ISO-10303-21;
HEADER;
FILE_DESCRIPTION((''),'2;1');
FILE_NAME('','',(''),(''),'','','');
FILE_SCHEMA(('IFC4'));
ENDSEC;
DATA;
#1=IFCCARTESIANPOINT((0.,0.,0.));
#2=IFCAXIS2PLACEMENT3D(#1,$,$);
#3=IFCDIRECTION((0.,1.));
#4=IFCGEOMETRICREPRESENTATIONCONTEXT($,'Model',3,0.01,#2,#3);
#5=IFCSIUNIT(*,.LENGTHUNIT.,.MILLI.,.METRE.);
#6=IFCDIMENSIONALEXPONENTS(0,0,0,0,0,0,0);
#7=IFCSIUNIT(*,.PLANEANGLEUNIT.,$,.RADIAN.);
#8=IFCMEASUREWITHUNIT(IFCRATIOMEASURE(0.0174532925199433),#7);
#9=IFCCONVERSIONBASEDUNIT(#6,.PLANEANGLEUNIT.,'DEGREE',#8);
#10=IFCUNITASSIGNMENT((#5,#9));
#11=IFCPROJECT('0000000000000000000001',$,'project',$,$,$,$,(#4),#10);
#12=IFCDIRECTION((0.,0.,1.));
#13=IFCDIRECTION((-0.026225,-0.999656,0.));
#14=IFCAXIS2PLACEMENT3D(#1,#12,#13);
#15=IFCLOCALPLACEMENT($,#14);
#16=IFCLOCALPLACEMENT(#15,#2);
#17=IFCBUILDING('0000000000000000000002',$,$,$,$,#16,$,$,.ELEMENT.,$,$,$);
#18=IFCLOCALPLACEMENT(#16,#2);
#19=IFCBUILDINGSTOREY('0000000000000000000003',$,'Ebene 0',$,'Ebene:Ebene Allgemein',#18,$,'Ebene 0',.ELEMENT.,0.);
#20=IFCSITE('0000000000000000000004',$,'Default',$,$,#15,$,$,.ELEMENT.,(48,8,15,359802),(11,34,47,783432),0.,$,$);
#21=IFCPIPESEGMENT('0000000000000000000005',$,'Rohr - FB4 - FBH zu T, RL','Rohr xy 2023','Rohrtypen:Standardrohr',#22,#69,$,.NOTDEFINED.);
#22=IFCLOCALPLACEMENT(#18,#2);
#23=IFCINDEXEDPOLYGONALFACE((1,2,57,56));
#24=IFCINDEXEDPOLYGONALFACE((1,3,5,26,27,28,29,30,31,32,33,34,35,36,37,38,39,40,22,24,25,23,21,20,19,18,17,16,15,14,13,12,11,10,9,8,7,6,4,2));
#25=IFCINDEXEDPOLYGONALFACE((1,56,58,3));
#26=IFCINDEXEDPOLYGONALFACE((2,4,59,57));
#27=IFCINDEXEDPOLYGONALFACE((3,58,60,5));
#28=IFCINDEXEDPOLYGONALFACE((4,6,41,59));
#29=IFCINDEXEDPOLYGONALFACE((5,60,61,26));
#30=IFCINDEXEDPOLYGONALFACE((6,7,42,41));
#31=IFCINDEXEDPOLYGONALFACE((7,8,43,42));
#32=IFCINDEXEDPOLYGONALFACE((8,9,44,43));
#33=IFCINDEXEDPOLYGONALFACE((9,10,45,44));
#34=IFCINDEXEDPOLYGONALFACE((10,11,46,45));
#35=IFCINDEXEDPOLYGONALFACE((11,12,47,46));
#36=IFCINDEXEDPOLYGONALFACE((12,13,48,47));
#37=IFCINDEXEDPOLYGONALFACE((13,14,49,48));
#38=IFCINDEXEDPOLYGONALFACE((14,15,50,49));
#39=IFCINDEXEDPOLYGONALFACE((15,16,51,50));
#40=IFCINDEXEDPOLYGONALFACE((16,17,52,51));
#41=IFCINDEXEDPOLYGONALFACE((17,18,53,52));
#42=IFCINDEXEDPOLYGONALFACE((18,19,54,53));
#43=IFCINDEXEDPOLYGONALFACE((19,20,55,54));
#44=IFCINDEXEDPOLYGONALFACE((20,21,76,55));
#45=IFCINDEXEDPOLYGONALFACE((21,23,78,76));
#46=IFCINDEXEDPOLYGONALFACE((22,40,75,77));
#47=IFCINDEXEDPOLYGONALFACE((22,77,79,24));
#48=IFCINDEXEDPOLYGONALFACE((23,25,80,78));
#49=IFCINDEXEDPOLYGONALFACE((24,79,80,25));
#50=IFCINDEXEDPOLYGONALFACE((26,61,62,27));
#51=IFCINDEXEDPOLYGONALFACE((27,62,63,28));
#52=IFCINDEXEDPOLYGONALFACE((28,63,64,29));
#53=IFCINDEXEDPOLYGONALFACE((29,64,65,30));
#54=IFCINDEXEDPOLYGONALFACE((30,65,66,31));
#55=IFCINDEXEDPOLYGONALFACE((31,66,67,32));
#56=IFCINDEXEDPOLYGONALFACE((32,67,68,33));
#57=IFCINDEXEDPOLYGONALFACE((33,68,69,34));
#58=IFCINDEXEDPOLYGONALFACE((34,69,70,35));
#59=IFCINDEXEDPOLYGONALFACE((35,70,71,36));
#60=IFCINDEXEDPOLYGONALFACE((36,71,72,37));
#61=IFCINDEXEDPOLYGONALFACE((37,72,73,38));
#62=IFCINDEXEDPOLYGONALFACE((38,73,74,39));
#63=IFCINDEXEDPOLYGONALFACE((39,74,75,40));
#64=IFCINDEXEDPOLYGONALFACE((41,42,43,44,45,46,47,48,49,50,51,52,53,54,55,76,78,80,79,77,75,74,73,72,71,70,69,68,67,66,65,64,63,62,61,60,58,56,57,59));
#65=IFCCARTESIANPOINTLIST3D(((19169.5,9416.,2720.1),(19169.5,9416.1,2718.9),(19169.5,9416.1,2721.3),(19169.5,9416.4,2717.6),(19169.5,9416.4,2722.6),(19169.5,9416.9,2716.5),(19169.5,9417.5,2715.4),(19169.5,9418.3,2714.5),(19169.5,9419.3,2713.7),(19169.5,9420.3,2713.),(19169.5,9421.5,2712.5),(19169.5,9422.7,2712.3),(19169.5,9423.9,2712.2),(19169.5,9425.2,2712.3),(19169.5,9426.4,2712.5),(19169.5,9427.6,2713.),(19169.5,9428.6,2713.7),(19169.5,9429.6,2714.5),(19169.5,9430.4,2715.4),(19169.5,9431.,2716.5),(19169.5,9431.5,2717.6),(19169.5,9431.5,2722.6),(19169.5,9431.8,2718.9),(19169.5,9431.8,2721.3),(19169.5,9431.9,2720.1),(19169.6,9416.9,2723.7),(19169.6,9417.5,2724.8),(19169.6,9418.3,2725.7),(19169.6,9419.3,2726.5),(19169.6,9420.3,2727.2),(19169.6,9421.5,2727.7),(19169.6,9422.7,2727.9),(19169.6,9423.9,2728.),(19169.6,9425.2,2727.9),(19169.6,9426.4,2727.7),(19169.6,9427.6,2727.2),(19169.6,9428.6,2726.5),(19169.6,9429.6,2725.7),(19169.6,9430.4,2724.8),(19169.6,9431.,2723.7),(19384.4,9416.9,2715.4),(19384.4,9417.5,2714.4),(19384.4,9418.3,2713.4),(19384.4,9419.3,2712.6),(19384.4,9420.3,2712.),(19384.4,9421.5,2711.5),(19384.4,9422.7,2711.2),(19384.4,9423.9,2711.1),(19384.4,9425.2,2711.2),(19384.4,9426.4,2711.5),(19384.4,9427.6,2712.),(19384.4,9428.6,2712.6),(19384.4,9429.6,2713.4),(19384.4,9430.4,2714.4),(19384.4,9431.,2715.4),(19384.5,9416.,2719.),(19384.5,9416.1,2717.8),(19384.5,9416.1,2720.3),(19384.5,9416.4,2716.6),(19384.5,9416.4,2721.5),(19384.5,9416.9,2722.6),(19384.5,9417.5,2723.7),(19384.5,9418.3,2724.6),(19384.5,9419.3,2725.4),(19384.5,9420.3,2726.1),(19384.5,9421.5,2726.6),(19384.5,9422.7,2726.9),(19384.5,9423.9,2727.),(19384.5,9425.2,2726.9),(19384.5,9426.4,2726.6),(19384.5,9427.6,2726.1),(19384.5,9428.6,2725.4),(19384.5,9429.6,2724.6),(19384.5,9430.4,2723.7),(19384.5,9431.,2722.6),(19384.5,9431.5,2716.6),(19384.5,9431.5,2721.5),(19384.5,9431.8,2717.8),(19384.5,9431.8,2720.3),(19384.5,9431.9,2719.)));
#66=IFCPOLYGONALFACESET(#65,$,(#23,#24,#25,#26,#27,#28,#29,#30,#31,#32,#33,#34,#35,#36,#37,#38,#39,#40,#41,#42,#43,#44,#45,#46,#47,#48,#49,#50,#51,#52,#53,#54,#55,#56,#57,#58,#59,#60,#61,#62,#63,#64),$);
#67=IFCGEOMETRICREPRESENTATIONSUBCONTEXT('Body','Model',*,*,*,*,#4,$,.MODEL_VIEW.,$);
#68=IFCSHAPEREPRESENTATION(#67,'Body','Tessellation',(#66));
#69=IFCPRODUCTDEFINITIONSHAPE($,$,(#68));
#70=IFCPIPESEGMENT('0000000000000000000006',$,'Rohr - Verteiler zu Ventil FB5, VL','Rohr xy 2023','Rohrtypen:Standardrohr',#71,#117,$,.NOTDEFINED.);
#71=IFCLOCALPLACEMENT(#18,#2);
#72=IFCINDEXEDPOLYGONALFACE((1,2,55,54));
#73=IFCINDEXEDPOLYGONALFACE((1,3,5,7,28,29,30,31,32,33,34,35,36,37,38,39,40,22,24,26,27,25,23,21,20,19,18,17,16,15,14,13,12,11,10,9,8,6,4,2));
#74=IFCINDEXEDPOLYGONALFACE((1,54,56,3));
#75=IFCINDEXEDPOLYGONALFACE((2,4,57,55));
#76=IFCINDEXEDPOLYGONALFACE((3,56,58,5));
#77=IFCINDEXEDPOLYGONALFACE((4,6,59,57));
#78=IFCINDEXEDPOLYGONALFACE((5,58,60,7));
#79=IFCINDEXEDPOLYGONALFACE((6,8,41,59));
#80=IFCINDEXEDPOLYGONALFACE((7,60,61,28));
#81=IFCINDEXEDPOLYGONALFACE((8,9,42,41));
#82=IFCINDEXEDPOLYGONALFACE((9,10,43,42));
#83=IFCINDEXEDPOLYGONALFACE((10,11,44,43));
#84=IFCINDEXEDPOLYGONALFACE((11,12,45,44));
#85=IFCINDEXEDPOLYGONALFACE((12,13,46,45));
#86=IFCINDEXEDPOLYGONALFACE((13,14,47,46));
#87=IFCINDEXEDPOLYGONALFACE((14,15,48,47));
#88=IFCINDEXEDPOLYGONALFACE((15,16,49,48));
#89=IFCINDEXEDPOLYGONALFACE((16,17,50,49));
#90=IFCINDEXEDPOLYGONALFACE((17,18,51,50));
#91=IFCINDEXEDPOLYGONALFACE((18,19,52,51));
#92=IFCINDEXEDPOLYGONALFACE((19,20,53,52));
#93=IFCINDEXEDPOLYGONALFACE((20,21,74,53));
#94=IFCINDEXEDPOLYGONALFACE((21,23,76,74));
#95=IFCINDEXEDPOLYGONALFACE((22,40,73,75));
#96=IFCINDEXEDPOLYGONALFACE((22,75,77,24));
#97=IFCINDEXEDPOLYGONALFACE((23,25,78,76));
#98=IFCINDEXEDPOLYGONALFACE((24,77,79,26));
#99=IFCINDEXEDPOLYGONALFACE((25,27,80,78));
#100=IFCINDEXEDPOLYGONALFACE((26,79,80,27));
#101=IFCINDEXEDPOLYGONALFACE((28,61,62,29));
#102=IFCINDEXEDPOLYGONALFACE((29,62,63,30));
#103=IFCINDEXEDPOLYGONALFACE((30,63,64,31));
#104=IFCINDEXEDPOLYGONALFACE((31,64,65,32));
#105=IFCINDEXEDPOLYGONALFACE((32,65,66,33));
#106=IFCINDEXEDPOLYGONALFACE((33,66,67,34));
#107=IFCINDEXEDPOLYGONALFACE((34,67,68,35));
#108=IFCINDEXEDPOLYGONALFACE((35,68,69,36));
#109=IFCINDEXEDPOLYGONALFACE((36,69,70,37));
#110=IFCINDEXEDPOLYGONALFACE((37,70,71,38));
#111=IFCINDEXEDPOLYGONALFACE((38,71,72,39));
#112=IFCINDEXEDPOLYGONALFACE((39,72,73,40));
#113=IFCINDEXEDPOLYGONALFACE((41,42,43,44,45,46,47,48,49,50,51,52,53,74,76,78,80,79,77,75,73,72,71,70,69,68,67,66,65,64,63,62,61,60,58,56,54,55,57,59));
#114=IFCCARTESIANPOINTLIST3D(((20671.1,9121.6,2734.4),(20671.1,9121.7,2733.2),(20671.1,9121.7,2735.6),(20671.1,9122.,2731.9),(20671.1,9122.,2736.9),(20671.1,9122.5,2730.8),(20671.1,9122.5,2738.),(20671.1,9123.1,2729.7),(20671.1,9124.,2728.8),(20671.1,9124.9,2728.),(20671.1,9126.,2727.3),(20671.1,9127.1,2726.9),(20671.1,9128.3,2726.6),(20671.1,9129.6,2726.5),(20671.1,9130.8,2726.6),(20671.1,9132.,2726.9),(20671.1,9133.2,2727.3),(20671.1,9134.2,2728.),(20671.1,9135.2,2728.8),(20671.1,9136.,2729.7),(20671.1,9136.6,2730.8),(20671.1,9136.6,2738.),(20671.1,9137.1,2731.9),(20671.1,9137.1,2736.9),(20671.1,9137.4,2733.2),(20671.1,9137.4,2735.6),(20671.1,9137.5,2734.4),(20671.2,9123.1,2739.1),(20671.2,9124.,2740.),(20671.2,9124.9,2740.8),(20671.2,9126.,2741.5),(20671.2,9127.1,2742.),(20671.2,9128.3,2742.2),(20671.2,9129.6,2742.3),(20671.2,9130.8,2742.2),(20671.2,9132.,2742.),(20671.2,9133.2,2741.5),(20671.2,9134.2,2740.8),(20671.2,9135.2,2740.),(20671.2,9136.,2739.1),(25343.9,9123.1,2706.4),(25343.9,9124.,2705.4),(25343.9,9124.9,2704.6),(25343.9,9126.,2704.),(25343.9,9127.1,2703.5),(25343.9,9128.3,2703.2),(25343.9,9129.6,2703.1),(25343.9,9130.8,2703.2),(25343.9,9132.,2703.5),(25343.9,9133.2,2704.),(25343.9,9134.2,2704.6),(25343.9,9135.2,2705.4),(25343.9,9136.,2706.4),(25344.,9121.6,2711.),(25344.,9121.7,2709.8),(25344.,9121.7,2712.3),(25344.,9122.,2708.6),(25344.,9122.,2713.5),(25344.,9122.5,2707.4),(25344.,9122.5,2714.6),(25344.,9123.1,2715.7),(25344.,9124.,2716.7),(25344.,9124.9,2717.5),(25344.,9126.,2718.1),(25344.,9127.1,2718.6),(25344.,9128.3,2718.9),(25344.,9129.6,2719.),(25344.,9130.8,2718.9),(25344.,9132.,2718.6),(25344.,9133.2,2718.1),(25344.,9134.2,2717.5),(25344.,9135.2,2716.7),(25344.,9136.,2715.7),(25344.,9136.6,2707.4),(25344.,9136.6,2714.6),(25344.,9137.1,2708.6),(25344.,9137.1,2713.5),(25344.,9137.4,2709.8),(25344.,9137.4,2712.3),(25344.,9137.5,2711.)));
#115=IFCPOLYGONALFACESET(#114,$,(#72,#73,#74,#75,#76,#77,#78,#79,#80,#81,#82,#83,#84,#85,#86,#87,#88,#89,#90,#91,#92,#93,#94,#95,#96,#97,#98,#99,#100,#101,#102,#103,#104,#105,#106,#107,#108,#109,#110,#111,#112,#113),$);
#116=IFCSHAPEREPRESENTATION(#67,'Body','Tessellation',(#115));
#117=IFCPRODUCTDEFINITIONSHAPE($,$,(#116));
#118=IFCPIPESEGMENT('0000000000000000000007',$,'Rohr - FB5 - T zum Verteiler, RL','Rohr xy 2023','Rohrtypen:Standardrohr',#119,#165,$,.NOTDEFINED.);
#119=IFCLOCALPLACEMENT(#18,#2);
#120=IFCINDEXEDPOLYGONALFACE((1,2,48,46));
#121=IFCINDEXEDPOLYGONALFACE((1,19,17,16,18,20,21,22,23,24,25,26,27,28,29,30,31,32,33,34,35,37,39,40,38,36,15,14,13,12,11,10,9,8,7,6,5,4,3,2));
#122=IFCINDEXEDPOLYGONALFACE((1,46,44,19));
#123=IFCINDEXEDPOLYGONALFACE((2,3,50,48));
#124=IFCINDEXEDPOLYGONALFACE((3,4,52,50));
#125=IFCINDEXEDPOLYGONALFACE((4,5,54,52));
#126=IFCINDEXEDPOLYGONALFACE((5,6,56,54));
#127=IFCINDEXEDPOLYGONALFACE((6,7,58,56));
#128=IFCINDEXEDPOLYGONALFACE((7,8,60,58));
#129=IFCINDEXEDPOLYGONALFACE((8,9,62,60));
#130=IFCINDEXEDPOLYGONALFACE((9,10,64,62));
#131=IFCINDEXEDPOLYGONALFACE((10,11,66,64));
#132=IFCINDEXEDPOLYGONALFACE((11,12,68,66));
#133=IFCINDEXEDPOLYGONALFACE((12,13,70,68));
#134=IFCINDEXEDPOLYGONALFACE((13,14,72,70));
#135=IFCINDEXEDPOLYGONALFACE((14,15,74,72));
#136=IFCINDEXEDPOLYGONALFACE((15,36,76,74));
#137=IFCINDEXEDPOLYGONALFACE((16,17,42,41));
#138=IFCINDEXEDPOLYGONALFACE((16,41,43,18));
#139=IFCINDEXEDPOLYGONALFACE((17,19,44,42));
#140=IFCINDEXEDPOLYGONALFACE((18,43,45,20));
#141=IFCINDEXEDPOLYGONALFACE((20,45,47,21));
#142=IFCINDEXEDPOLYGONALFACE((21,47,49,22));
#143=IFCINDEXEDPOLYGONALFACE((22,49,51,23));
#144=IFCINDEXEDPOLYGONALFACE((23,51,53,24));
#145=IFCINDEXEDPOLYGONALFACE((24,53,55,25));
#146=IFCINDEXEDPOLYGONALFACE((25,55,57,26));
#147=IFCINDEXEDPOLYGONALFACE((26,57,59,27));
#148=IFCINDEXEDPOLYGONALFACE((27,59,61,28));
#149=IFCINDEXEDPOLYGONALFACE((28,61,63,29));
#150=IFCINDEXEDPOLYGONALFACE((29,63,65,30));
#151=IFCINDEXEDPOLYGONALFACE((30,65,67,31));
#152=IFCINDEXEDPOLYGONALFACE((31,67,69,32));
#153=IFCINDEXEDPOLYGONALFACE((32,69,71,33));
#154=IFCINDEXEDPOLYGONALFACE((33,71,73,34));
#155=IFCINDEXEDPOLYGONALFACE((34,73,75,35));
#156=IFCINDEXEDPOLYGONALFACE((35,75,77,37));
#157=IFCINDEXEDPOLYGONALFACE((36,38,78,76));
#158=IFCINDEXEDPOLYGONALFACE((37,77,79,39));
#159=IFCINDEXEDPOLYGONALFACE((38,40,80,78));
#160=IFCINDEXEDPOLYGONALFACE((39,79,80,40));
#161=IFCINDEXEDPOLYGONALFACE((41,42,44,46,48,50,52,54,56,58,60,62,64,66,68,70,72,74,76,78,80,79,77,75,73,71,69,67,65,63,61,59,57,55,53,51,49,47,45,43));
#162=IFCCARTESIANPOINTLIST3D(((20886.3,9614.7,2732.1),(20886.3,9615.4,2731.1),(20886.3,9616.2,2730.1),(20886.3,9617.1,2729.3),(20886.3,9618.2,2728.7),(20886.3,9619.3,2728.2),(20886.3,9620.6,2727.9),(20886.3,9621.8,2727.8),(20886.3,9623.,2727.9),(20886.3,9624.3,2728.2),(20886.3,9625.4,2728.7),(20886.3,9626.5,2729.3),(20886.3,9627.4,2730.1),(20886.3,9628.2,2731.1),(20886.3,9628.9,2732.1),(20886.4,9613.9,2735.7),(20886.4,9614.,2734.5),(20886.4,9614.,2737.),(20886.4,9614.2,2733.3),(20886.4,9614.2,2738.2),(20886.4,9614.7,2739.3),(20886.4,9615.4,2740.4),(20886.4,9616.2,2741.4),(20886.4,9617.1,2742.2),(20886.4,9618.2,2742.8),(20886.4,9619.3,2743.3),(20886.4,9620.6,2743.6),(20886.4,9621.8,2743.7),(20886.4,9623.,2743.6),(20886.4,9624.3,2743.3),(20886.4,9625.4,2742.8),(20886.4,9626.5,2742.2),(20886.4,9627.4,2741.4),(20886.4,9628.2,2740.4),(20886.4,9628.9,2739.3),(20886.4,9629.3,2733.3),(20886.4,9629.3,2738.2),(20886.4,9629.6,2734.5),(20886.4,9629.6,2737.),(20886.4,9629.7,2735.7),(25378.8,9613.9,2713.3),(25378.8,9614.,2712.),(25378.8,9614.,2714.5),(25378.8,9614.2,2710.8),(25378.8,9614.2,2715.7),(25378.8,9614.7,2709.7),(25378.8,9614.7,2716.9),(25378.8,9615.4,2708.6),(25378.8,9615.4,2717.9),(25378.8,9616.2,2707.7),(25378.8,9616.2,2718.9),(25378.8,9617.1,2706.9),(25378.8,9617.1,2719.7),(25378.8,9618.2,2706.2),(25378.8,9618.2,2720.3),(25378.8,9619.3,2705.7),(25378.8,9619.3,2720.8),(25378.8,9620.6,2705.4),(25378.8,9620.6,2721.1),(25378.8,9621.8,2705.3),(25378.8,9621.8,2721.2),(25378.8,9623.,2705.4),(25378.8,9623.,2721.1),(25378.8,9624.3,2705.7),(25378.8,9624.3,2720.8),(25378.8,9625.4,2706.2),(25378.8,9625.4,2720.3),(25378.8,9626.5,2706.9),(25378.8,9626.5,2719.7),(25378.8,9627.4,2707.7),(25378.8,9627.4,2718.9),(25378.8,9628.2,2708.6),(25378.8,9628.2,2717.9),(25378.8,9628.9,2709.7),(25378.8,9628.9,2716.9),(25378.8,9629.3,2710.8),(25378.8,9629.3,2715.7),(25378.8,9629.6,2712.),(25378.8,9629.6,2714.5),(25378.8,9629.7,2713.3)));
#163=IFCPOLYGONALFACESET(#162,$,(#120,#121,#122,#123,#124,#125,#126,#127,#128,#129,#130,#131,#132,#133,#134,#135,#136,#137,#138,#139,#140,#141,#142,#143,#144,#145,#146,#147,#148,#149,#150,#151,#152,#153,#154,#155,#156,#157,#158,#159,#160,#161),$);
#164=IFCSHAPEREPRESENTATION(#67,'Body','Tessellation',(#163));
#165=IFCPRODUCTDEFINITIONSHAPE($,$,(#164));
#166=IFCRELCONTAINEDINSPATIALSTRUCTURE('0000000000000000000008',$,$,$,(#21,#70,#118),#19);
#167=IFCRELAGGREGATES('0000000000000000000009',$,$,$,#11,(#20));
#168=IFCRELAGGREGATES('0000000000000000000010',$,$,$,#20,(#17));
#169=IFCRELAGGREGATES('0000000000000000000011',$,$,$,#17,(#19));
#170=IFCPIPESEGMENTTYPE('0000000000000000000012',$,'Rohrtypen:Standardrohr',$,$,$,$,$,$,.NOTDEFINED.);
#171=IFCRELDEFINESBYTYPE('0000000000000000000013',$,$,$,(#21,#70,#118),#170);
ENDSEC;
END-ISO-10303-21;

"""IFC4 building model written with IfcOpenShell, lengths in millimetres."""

from ifc_helpers import new_model, entity, si_unit, converted_unit, direction, frame, origin, place, context, subcontext, project, spatial, indexed_curve, outline, extrude, type_object, element, save


model = new_model("IFC4")

# Units and contexts
model_context = context("Model", 3, precision=0.01, world=origin(), true_north=direction((0.0, 1.0)))
body_context = subcontext(model_context, "Body", "Model", "MODEL_VIEW")
ifc_project = project(units=[si_unit("LENGTHUNIT", "METRE", prefix="MILLI"), converted_unit("PLANEANGLEUNIT", "DEGREE", entity("IfcRatioMeasure", 0.0174532925199433), si_unit("PLANEANGLEUNIT", "RADIAN"), dimensions=[0, 0, 0, 0, 0, 0, 0])], contexts=[model_context])

# Site, building, storey
site_placement = place(None, frame((0.0, 0.0, 0.0), z_axis=(0.0, 0.0, 1.0), x_axis=(-0.026225, -0.999656, 0.0)))
site = spatial("IfcSite", under=ifc_project, at=site_placement, Name="Default", CompositionType="ELEMENT", RefLatitude=(48, 8, 15, 359802), RefLongitude=(11, 34, 47, 783432), RefElevation=0.0)
building_placement = place(site_placement, origin())
building = spatial("IfcBuilding", under=site, at=building_placement, CompositionType="ELEMENT")
storey_placement = place(building_placement, origin())
storey = spatial("IfcBuildingStorey", under=building, at=storey_placement, Name="Ebene 0", ObjectType="Ebene:Ebene Allgemein", LongName="Ebene 0", CompositionType="ELEMENT", Elevation=0.0)

# Pipe segments
pipe_segment_type = type_object("IfcPipeSegmentType", Name="Rohrtypen:Standardrohr", PredefinedType="NOTDEFINED")
pipe_segment_1_placement = place(storey_placement, origin())
element("IfcPipeSegment", 1, at=pipe_segment_1_placement, inside=storey, type_object=pipe_segment_type, Name="Rohr - FB4 - FBH zu T, RL", Description="Rohr xy 2023", ObjectType="Rohrtypen:Standardrohr", PredefinedType="NOTDEFINED", context=body_context, shape_type="SweptSolid", body=[
    extrude(outline(indexed_curve([(7.9, 0.0), (7.8, 1.2), (7.6, 2.5), (7.1, 3.6), (6.4, 4.7), (5.6, 5.6), (4.7, 6.4), (3.6, 7.1), (2.5, 7.6), (1.2, 7.8), (0.0, 7.9), (-1.2, 7.8), (-2.5, 7.6), (-3.6, 7.1), (-4.7, 6.4), (-5.6, 5.6), (-6.4, 4.7), (-7.1, 3.6), (-7.6, 2.5), (-7.8, 1.2), (-7.9, 0.0), (-7.8, -1.2), (-7.6, -2.5), (-7.1, -3.6), (-6.4, -4.7), (-5.6, -5.6), (-4.7, -6.4), (-3.6, -7.1), (-2.5, -7.6), (-1.2, -7.8), (0.0, -7.9), (1.2, -7.8), (2.5, -7.6), (3.6, -7.1), (4.7, -6.4), (5.6, -5.6), (6.4, -4.7), (7.1, -3.6), (7.6, -2.5), (7.8, -1.2), (7.9, 0.0)], self_intersect=False)), frame((19384.5, 9423.9, 2719.0), z_axis=(-0.999988, 0.0, 0.005), x_axis=(0.0, 1.0, 0.0)), (0.0, 0.0, 1.0), 214.9),
])
pipe_segment_2_placement = place(storey_placement, origin())
element("IfcPipeSegment", 2, at=pipe_segment_2_placement, inside=storey, type_object=pipe_segment_type, Name="Rohr - Verteiler zu Ventil FB5, VL", Description="Rohr xy 2023", ObjectType="Rohrtypen:Standardrohr", PredefinedType="NOTDEFINED", context=body_context, shape_type="SweptSolid", body=[
    extrude(outline(indexed_curve([(7.9, 0.0), (7.8, 1.2), (7.6, 2.5), (7.1, 3.6), (6.4, 4.7), (5.6, 5.6), (4.7, 6.4), (3.6, 7.1), (2.5, 7.6), (1.2, 7.8), (0.0, 7.9), (-1.2, 7.8), (-2.5, 7.6), (-3.6, 7.1), (-4.7, 6.4), (-5.6, 5.6), (-6.4, 4.7), (-7.1, 3.6), (-7.6, 2.5), (-7.8, 1.2), (-7.9, 0.0), (-7.8, -1.2), (-7.6, -2.5), (-7.1, -3.6), (-6.4, -4.7), (-5.6, -5.6), (-4.7, -6.4), (-3.6, -7.1), (-2.5, -7.6), (-1.2, -7.8), (0.0, -7.9), (1.2, -7.8), (2.5, -7.6), (3.6, -7.1), (4.7, -6.4), (5.6, -5.6), (6.4, -4.7), (7.1, -3.6), (7.6, -2.5), (7.8, -1.2), (7.9, 0.0)], self_intersect=False)), frame((25344.0, 9129.6, 2711.0), z_axis=(-0.999988, 0.0, 0.005), x_axis=(0.0, 1.0, 0.0)), (0.0, 0.0, 1.0), 4672.9),
])
pipe_segment_3_placement = place(storey_placement, origin())
element("IfcPipeSegment", 3, at=pipe_segment_3_placement, inside=storey, type_object=pipe_segment_type, Name="Rohr - FB5 - T zum Verteiler, RL", Description="Rohr xy 2023", ObjectType="Rohrtypen:Standardrohr", PredefinedType="NOTDEFINED", context=body_context, shape_type="SweptSolid", body=[
    extrude(outline(indexed_curve([(7.9, 0.0), (7.8, 1.2), (7.6, 2.5), (7.1, 3.6), (6.4, 4.7), (5.6, 5.6), (4.7, 6.4), (3.6, 7.1), (2.5, 7.6), (1.2, 7.8), (0.0, 7.9), (-1.2, 7.8), (-2.5, 7.6), (-3.6, 7.1), (-4.7, 6.4), (-5.6, 5.6), (-6.4, 4.7), (-7.1, 3.6), (-7.6, 2.5), (-7.8, 1.2), (-7.9, 0.0), (-7.8, -1.2), (-7.6, -2.5), (-7.1, -3.6), (-6.4, -4.7), (-5.6, -5.6), (-4.7, -6.4), (-3.6, -7.1), (-2.5, -7.6), (-1.2, -7.8), (0.0, -7.9), (1.2, -7.8), (2.5, -7.6), (3.6, -7.1), (4.7, -6.4), (5.6, -5.6), (6.4, -4.7), (7.1, -3.6), (7.6, -2.5), (7.8, -1.2), (7.9, 0.0)], self_intersect=False)), frame((25378.8, 9621.8, 2713.3), z_axis=(-0.999988, 0.0, 0.005), x_axis=(0.0, 1.0, 0.0)), (0.0, 0.0, 1.0), 4492.5),
])

save(model, "model.ifc")
